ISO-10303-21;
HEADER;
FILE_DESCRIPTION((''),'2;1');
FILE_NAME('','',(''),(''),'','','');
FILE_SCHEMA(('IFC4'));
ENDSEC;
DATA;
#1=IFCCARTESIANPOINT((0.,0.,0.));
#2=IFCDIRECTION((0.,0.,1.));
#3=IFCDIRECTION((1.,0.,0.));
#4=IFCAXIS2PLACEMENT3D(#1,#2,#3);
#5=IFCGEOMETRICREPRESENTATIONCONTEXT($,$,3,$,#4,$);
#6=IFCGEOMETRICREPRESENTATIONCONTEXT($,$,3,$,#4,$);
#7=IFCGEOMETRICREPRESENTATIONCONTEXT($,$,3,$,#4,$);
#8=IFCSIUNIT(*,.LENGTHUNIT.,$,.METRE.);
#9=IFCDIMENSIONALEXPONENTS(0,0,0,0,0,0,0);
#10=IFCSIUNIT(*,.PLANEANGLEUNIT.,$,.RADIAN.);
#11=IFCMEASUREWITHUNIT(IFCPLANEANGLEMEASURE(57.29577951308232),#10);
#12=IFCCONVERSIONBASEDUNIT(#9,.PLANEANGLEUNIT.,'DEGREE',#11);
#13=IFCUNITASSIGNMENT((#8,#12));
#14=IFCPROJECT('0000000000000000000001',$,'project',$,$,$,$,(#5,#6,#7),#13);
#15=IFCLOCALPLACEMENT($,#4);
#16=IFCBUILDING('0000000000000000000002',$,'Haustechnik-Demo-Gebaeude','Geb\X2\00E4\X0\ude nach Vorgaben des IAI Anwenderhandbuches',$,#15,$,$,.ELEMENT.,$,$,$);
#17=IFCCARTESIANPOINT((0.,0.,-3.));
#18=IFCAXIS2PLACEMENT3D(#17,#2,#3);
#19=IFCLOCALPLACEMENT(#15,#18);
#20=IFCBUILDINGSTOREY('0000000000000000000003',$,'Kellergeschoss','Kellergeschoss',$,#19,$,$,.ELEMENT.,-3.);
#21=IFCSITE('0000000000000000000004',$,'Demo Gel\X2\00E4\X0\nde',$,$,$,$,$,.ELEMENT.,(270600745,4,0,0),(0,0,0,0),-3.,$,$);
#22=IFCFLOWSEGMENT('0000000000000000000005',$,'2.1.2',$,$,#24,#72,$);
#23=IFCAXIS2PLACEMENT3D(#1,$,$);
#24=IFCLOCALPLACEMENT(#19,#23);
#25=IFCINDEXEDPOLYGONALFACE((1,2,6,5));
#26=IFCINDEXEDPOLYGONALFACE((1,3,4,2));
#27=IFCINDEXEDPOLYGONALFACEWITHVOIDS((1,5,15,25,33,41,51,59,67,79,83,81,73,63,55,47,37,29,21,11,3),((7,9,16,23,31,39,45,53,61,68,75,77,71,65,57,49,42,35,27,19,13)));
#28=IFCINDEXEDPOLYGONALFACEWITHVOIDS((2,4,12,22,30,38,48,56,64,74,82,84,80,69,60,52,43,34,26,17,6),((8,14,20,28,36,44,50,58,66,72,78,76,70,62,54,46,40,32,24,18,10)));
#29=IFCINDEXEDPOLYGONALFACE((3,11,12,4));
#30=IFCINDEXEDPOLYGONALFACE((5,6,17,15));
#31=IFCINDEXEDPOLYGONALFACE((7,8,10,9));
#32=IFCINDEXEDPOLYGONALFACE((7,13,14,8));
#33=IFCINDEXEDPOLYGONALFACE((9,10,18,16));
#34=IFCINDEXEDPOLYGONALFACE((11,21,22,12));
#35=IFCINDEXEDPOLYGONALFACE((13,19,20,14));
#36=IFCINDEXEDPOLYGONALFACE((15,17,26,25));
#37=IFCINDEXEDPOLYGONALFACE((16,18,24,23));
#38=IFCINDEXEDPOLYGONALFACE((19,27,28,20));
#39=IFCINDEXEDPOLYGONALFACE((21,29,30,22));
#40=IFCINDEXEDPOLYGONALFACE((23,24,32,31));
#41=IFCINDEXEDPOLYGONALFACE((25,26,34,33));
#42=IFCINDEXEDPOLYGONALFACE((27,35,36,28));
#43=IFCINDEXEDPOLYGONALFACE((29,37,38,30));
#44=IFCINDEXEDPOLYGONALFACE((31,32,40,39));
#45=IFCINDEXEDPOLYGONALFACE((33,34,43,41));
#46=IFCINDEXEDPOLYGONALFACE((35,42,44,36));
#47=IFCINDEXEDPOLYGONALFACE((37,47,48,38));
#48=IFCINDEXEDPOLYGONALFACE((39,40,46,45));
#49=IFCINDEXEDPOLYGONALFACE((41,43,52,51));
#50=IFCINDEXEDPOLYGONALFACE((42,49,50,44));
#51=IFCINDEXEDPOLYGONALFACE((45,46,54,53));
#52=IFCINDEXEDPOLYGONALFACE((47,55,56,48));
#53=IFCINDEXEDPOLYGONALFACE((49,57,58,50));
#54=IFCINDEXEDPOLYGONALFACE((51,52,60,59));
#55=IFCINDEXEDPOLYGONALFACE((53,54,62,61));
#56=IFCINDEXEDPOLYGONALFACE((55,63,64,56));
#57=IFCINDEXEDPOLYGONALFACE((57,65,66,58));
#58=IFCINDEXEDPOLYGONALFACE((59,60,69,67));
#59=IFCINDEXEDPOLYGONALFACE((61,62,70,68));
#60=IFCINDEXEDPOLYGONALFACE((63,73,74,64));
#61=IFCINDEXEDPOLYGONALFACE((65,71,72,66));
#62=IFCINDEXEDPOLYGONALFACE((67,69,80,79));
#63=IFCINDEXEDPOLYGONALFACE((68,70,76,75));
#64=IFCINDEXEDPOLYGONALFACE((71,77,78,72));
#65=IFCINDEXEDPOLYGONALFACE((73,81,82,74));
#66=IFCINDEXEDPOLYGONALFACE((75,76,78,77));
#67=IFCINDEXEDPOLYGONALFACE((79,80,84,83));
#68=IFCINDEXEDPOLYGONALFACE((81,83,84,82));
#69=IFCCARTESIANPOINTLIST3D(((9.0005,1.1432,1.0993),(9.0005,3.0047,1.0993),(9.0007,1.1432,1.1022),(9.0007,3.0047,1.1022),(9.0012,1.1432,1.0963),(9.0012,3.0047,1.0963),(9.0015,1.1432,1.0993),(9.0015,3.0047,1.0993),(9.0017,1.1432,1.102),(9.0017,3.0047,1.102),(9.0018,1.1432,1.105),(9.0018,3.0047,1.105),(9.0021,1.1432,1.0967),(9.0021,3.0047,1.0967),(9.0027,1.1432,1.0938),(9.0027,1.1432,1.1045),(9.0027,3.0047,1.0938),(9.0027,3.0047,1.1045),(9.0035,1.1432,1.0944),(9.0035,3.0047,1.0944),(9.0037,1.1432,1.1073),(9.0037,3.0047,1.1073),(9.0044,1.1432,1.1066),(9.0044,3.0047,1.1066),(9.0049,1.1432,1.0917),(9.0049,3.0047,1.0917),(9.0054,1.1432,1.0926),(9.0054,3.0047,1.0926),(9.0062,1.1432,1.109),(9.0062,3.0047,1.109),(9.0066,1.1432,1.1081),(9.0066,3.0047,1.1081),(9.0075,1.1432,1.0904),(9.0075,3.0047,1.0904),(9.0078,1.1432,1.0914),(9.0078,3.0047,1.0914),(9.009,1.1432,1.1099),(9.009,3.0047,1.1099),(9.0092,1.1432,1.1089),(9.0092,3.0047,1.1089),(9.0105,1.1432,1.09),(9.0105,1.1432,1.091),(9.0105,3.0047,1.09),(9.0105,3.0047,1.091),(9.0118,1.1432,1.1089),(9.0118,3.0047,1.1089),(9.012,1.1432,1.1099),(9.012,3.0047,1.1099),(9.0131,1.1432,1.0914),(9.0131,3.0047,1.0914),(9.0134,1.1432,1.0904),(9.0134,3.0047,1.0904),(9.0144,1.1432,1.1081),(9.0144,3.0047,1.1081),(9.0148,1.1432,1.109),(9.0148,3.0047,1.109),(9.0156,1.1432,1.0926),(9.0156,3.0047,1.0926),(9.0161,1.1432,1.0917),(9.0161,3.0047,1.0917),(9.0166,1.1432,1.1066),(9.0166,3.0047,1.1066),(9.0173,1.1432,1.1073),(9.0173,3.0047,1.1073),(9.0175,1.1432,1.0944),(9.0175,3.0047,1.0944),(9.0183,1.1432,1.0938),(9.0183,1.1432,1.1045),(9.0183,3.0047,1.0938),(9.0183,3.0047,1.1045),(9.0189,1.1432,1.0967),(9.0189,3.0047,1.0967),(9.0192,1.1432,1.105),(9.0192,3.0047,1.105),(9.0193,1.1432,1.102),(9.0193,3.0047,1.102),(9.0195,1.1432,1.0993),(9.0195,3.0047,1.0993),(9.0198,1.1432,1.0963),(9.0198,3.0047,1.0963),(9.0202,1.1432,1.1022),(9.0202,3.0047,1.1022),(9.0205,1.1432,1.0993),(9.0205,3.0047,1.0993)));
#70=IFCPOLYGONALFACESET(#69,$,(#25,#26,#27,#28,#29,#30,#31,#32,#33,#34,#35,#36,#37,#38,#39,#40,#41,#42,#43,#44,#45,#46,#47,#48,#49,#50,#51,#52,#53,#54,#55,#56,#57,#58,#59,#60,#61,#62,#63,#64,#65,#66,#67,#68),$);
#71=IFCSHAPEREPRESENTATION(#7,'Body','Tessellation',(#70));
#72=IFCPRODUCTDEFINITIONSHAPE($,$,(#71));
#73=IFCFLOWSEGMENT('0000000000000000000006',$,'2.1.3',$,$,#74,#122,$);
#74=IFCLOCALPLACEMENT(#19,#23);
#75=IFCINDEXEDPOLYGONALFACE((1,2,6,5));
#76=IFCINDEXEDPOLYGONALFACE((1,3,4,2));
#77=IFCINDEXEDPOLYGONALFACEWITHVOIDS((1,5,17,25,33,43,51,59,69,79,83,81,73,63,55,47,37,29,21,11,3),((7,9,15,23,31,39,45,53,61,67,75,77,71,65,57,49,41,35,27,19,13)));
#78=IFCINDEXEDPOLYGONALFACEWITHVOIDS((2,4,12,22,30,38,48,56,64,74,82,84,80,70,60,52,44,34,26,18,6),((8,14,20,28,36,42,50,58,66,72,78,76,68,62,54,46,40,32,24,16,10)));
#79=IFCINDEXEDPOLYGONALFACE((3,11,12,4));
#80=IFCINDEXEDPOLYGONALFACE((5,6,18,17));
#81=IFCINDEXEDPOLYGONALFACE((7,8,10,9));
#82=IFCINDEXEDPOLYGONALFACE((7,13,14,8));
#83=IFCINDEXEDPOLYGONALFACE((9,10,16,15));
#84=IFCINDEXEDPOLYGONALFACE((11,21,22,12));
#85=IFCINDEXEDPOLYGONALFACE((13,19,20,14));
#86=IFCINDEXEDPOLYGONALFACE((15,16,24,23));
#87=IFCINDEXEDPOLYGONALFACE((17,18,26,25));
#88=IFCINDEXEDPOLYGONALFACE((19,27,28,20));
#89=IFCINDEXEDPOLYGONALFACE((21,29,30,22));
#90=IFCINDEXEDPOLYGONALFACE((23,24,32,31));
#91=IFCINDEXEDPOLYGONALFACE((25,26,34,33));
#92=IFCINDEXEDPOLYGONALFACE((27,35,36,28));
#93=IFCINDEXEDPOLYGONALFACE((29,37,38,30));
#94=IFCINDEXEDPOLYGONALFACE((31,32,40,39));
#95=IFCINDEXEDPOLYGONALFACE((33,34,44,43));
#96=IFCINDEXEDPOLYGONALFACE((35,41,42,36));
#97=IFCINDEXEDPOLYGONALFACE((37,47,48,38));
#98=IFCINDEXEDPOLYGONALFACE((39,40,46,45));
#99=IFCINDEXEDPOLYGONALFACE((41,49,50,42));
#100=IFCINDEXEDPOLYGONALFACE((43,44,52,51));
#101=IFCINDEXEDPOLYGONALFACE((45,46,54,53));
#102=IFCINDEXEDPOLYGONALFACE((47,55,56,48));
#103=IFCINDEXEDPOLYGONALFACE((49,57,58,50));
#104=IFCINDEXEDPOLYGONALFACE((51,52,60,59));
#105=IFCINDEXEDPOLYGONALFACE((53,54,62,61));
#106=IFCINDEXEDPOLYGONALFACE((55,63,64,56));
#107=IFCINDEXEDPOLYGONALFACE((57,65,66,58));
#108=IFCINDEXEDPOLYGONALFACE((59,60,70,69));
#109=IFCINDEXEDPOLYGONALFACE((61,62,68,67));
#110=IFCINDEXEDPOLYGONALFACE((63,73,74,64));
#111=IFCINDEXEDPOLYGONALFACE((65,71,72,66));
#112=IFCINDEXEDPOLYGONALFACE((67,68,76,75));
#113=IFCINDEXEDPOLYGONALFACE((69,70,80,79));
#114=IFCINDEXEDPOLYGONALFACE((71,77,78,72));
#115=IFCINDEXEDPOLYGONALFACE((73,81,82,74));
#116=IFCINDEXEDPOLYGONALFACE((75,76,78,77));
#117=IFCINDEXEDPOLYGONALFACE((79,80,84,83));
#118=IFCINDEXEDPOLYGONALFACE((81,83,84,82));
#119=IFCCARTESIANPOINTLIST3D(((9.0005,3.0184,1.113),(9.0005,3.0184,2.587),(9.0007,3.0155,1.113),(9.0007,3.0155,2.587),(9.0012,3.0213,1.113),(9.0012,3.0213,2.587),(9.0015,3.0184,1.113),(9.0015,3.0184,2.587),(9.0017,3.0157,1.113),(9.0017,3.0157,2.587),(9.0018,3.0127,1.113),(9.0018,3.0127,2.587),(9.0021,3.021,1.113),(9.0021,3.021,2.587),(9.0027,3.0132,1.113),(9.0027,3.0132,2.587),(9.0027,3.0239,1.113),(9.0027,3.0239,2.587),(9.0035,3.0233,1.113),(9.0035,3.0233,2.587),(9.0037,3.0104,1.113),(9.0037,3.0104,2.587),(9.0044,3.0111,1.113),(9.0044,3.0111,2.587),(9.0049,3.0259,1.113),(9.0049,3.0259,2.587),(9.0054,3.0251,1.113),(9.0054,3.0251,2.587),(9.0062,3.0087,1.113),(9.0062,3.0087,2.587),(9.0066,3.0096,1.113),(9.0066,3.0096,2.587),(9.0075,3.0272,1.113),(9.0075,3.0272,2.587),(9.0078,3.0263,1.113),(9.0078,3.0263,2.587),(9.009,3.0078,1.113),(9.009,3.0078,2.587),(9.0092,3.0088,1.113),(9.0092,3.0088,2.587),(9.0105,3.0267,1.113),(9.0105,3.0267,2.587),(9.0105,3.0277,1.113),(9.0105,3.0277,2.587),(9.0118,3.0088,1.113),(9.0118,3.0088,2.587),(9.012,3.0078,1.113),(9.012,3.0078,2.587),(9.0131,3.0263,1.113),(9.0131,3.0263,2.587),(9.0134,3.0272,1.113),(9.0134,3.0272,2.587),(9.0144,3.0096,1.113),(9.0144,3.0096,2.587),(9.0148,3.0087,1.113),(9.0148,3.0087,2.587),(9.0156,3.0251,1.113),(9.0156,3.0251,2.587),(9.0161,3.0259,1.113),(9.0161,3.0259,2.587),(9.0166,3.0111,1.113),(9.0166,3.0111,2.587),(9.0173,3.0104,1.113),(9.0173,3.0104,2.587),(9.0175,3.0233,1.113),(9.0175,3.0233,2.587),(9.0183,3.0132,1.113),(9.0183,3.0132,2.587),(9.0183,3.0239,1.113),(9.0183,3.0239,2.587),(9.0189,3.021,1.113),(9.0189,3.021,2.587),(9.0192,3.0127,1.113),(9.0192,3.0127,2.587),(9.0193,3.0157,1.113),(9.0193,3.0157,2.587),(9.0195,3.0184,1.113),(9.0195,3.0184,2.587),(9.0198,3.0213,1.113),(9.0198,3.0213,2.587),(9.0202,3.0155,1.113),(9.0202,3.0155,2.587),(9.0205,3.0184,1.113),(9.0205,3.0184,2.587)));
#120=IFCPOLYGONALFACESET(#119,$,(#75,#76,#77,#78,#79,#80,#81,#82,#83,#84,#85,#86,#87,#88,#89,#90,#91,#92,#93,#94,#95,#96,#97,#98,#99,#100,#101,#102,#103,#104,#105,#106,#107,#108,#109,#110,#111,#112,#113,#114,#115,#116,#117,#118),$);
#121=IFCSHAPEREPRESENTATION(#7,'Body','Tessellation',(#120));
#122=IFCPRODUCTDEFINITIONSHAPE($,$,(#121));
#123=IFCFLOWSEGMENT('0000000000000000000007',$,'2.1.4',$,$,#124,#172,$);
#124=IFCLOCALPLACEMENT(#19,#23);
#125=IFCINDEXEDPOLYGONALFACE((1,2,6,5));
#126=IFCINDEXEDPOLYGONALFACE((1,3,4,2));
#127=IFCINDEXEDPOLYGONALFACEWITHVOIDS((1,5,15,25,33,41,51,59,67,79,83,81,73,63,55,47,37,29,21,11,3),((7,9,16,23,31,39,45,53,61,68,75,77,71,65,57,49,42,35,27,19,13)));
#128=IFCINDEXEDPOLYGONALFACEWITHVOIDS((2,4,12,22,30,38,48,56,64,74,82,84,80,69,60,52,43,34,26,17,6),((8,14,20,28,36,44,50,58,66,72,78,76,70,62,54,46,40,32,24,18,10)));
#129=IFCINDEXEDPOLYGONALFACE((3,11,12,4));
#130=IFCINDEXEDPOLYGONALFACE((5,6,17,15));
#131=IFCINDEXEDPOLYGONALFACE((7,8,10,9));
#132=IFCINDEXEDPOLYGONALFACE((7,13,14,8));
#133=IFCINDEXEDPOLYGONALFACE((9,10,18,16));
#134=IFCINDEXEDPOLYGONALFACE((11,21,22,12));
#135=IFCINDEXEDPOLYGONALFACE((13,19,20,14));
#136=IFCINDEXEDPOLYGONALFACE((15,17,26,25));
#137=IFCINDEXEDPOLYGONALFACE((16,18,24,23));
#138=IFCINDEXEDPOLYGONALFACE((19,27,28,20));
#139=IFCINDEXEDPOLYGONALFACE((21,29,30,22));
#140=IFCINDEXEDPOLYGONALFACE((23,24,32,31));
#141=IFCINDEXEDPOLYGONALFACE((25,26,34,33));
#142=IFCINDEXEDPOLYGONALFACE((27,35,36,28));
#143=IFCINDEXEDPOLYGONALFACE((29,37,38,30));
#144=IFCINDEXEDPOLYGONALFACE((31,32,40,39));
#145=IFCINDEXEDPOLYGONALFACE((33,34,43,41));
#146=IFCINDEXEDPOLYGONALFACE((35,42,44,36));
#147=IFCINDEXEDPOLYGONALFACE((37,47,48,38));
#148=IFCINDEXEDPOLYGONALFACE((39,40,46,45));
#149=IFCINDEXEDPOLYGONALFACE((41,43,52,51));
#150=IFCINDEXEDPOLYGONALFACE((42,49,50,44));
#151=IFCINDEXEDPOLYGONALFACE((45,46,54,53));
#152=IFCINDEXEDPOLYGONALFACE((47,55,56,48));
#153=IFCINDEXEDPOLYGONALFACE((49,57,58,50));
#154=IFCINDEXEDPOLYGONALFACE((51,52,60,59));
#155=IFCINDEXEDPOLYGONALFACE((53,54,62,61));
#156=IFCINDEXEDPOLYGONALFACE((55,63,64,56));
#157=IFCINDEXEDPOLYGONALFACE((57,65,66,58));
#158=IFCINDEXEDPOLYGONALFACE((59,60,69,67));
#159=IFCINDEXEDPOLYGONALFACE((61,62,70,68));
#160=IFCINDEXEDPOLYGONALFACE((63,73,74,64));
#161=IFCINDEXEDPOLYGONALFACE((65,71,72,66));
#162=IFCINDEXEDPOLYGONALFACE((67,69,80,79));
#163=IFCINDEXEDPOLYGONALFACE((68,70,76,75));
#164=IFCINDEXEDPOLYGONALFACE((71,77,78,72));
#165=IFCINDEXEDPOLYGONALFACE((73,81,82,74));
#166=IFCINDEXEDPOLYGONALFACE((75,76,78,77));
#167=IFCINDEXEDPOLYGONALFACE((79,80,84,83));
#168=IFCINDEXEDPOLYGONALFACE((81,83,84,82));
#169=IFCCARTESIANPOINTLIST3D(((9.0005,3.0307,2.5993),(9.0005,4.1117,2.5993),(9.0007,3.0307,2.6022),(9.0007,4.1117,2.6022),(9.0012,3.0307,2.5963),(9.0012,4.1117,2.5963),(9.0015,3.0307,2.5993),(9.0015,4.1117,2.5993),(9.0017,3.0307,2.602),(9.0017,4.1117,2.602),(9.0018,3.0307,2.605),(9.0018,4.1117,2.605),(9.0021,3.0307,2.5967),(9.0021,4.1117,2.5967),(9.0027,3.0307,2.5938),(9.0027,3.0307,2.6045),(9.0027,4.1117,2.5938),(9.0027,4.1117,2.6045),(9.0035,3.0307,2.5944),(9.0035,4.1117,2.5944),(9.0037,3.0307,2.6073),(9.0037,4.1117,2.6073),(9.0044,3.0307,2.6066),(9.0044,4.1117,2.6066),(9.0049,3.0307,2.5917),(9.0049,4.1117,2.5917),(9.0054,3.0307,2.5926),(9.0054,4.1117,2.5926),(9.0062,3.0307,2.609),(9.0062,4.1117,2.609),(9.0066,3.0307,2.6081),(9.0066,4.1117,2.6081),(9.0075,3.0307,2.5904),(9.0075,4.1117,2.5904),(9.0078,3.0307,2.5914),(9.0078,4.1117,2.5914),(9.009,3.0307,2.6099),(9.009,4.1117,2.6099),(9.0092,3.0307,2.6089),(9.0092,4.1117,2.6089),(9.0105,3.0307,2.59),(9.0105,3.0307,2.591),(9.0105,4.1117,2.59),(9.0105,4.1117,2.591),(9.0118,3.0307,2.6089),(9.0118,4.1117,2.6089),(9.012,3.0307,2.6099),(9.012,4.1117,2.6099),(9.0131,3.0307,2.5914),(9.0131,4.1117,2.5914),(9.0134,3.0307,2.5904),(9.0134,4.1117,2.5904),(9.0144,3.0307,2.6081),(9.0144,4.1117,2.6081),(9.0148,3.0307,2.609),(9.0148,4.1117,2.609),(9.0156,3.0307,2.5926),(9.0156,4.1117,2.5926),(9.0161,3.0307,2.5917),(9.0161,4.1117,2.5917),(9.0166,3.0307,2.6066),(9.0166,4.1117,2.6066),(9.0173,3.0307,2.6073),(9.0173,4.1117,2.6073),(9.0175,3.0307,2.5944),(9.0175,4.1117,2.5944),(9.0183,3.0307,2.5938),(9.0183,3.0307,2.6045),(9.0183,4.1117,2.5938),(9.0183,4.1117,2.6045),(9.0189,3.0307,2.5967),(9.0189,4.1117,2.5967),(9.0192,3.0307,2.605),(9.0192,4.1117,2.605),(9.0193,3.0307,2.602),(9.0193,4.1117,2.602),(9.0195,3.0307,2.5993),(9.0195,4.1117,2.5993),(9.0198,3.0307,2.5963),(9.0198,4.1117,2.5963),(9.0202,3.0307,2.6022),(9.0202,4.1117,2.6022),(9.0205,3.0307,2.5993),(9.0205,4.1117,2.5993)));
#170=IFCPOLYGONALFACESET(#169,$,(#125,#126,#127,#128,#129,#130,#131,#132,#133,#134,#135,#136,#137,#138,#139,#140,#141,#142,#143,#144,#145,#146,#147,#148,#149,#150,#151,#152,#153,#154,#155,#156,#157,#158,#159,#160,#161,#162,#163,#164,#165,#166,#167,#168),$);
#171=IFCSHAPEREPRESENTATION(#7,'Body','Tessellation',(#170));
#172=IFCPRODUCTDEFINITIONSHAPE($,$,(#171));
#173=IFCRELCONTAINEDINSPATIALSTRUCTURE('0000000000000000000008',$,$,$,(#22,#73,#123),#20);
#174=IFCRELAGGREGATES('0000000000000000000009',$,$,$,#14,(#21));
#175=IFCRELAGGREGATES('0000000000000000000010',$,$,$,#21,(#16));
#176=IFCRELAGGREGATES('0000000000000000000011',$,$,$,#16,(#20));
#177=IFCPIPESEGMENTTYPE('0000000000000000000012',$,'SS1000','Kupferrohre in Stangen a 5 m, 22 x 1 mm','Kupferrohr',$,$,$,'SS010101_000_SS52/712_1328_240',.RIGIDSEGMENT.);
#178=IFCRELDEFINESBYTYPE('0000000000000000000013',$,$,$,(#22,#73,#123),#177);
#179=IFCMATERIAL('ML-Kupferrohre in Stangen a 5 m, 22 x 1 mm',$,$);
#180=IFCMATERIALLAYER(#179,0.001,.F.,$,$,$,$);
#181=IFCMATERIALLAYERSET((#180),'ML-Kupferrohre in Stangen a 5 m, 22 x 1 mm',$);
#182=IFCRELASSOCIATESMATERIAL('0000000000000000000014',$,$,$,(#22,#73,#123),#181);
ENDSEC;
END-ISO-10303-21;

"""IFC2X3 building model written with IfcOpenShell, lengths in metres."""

from ifc_helpers import new_model, entity, si_unit, converted_unit, frame, origin_with_axes, origin_2d_with_axis, place, context, project, spatial, hollow_circle, extrude, material, layer, layer_set, layer_usage, type_object, element, save


model = new_model("IFC2X3")

# Units and contexts
context_of_model_1 = context(None, 3, world=origin_with_axes())
context_of_model_2 = context(None, 3, world=origin_with_axes())
context_of_model_3 = context(None, 3, world=origin_with_axes())
ifc_project = project(units=[si_unit("LENGTHUNIT", "METRE"), converted_unit("PLANEANGLEUNIT", "DEGREE", entity("IfcPlaneAngleMeasure", 57.29577951308232), si_unit("PLANEANGLEUNIT", "RADIAN"), dimensions=[0, 0, 0, 0, 0, 0, 0])], contexts=[context_of_model_1, context_of_model_2, context_of_model_3])

# Site, building, storey
site = spatial("IfcSite", under=ifc_project, Name="Demo Gelände", CompositionType="ELEMENT", RefLatitude=(270600745, 4, 0, 0), RefLongitude=(0, 0, 0, 0), RefElevation=-3.0)
building_placement = place(None, origin_with_axes())
building = spatial("IfcBuilding", under=site, at=building_placement, Name="Haustechnik-Demo-Gebaeude", Description="Gebäude nach Vorgaben des IAI Anwenderhandbuches", CompositionType="ELEMENT")
storey_placement = place(building_placement, frame((0.0, 0.0, -3.0), z_axis=(0.0, 0.0, 1.0), x_axis=(1.0, 0.0, 0.0)))
storey = spatial("IfcBuildingStorey", under=building, at=storey_placement, Name="Kellergeschoss", Description="Kellergeschoss", CompositionType="ELEMENT", Elevation=-3.0)

# Flow segments
ifc_material = material(Name="ML-Kupferrohre in Stangen a 5 m, 22 x 1 mm")
ifc_layer = layer(ifc_material, 0.001, ventilated=False)
ifc_layer_set = layer_set([ifc_layer], Name="ML-Kupferrohre in Stangen a 5 m, 22 x 1 mm")
ifc_layer_usage = layer_usage(ifc_layer_set, "AXIS2", "POSITIVE", 0.0)
pipe_segment_type_1 = type_object("IfcPipeSegmentType", Name="SS1000", Description="Kupferrohre in Stangen a 5 m, 22 x 1 mm", ApplicableOccurrence="Kupferrohr", ElementType="SS010101_000_SS52/712_1328_240", PredefinedType="RIGIDSEGMENT")
flow_segment_1_placement = place(storey_placement, frame((9.0105, 1.1432, 1.1), z_axis=(0.0, 1.0, 0.0), x_axis=(0.0, 0.0, -1.0)))
element("IfcFlowSegment", 1, at=flow_segment_1_placement, inside=storey, type_object=pipe_segment_type_1, material=ifc_layer_usage, Name="2.1.2", context=context_of_model_3, shape_type="SweptSolid", body=[
    extrude(hollow_circle(Radius=0.01, WallThickness=0.001, at=origin_2d_with_axis()), origin_with_axes(), (0.0, 0.0, 1.0), 1.8614),
])
flow_segment_2_placement = place(storey_placement, frame((9.0105, 3.0177, 1.113), z_axis=(0.0, 0.0, 1.0), x_axis=(0.0, 1.0, 0.0)))
element("IfcFlowSegment", 2, at=flow_segment_2_placement, inside=storey, type_object=pipe_segment_type_1, material=ifc_layer_usage, Name="2.1.3", context=context_of_model_3, shape_type="SweptSolid", body=[
    extrude(hollow_circle(Radius=0.01, WallThickness=0.001, at=origin_2d_with_axis()), origin_with_axes(), (0.0, 0.0, 1.0), 1.474),
])
flow_segment_3_placement = place(storey_placement, frame((9.0105, 3.0307, 2.6), z_axis=(0.0, 1.0, 0.0), x_axis=(0.0, 0.0, -1.0)))
element("IfcFlowSegment", 3, at=flow_segment_3_placement, inside=storey, type_object=pipe_segment_type_1, material=ifc_layer_usage, Name="2.1.4", context=context_of_model_3, shape_type="SweptSolid", body=[
    extrude(hollow_circle(Radius=0.01, WallThickness=0.001, at=origin_2d_with_axis()), origin_with_axes(), (0.0, 0.0, 1.0), 1.081),
])

save(model, "model.ifc")
